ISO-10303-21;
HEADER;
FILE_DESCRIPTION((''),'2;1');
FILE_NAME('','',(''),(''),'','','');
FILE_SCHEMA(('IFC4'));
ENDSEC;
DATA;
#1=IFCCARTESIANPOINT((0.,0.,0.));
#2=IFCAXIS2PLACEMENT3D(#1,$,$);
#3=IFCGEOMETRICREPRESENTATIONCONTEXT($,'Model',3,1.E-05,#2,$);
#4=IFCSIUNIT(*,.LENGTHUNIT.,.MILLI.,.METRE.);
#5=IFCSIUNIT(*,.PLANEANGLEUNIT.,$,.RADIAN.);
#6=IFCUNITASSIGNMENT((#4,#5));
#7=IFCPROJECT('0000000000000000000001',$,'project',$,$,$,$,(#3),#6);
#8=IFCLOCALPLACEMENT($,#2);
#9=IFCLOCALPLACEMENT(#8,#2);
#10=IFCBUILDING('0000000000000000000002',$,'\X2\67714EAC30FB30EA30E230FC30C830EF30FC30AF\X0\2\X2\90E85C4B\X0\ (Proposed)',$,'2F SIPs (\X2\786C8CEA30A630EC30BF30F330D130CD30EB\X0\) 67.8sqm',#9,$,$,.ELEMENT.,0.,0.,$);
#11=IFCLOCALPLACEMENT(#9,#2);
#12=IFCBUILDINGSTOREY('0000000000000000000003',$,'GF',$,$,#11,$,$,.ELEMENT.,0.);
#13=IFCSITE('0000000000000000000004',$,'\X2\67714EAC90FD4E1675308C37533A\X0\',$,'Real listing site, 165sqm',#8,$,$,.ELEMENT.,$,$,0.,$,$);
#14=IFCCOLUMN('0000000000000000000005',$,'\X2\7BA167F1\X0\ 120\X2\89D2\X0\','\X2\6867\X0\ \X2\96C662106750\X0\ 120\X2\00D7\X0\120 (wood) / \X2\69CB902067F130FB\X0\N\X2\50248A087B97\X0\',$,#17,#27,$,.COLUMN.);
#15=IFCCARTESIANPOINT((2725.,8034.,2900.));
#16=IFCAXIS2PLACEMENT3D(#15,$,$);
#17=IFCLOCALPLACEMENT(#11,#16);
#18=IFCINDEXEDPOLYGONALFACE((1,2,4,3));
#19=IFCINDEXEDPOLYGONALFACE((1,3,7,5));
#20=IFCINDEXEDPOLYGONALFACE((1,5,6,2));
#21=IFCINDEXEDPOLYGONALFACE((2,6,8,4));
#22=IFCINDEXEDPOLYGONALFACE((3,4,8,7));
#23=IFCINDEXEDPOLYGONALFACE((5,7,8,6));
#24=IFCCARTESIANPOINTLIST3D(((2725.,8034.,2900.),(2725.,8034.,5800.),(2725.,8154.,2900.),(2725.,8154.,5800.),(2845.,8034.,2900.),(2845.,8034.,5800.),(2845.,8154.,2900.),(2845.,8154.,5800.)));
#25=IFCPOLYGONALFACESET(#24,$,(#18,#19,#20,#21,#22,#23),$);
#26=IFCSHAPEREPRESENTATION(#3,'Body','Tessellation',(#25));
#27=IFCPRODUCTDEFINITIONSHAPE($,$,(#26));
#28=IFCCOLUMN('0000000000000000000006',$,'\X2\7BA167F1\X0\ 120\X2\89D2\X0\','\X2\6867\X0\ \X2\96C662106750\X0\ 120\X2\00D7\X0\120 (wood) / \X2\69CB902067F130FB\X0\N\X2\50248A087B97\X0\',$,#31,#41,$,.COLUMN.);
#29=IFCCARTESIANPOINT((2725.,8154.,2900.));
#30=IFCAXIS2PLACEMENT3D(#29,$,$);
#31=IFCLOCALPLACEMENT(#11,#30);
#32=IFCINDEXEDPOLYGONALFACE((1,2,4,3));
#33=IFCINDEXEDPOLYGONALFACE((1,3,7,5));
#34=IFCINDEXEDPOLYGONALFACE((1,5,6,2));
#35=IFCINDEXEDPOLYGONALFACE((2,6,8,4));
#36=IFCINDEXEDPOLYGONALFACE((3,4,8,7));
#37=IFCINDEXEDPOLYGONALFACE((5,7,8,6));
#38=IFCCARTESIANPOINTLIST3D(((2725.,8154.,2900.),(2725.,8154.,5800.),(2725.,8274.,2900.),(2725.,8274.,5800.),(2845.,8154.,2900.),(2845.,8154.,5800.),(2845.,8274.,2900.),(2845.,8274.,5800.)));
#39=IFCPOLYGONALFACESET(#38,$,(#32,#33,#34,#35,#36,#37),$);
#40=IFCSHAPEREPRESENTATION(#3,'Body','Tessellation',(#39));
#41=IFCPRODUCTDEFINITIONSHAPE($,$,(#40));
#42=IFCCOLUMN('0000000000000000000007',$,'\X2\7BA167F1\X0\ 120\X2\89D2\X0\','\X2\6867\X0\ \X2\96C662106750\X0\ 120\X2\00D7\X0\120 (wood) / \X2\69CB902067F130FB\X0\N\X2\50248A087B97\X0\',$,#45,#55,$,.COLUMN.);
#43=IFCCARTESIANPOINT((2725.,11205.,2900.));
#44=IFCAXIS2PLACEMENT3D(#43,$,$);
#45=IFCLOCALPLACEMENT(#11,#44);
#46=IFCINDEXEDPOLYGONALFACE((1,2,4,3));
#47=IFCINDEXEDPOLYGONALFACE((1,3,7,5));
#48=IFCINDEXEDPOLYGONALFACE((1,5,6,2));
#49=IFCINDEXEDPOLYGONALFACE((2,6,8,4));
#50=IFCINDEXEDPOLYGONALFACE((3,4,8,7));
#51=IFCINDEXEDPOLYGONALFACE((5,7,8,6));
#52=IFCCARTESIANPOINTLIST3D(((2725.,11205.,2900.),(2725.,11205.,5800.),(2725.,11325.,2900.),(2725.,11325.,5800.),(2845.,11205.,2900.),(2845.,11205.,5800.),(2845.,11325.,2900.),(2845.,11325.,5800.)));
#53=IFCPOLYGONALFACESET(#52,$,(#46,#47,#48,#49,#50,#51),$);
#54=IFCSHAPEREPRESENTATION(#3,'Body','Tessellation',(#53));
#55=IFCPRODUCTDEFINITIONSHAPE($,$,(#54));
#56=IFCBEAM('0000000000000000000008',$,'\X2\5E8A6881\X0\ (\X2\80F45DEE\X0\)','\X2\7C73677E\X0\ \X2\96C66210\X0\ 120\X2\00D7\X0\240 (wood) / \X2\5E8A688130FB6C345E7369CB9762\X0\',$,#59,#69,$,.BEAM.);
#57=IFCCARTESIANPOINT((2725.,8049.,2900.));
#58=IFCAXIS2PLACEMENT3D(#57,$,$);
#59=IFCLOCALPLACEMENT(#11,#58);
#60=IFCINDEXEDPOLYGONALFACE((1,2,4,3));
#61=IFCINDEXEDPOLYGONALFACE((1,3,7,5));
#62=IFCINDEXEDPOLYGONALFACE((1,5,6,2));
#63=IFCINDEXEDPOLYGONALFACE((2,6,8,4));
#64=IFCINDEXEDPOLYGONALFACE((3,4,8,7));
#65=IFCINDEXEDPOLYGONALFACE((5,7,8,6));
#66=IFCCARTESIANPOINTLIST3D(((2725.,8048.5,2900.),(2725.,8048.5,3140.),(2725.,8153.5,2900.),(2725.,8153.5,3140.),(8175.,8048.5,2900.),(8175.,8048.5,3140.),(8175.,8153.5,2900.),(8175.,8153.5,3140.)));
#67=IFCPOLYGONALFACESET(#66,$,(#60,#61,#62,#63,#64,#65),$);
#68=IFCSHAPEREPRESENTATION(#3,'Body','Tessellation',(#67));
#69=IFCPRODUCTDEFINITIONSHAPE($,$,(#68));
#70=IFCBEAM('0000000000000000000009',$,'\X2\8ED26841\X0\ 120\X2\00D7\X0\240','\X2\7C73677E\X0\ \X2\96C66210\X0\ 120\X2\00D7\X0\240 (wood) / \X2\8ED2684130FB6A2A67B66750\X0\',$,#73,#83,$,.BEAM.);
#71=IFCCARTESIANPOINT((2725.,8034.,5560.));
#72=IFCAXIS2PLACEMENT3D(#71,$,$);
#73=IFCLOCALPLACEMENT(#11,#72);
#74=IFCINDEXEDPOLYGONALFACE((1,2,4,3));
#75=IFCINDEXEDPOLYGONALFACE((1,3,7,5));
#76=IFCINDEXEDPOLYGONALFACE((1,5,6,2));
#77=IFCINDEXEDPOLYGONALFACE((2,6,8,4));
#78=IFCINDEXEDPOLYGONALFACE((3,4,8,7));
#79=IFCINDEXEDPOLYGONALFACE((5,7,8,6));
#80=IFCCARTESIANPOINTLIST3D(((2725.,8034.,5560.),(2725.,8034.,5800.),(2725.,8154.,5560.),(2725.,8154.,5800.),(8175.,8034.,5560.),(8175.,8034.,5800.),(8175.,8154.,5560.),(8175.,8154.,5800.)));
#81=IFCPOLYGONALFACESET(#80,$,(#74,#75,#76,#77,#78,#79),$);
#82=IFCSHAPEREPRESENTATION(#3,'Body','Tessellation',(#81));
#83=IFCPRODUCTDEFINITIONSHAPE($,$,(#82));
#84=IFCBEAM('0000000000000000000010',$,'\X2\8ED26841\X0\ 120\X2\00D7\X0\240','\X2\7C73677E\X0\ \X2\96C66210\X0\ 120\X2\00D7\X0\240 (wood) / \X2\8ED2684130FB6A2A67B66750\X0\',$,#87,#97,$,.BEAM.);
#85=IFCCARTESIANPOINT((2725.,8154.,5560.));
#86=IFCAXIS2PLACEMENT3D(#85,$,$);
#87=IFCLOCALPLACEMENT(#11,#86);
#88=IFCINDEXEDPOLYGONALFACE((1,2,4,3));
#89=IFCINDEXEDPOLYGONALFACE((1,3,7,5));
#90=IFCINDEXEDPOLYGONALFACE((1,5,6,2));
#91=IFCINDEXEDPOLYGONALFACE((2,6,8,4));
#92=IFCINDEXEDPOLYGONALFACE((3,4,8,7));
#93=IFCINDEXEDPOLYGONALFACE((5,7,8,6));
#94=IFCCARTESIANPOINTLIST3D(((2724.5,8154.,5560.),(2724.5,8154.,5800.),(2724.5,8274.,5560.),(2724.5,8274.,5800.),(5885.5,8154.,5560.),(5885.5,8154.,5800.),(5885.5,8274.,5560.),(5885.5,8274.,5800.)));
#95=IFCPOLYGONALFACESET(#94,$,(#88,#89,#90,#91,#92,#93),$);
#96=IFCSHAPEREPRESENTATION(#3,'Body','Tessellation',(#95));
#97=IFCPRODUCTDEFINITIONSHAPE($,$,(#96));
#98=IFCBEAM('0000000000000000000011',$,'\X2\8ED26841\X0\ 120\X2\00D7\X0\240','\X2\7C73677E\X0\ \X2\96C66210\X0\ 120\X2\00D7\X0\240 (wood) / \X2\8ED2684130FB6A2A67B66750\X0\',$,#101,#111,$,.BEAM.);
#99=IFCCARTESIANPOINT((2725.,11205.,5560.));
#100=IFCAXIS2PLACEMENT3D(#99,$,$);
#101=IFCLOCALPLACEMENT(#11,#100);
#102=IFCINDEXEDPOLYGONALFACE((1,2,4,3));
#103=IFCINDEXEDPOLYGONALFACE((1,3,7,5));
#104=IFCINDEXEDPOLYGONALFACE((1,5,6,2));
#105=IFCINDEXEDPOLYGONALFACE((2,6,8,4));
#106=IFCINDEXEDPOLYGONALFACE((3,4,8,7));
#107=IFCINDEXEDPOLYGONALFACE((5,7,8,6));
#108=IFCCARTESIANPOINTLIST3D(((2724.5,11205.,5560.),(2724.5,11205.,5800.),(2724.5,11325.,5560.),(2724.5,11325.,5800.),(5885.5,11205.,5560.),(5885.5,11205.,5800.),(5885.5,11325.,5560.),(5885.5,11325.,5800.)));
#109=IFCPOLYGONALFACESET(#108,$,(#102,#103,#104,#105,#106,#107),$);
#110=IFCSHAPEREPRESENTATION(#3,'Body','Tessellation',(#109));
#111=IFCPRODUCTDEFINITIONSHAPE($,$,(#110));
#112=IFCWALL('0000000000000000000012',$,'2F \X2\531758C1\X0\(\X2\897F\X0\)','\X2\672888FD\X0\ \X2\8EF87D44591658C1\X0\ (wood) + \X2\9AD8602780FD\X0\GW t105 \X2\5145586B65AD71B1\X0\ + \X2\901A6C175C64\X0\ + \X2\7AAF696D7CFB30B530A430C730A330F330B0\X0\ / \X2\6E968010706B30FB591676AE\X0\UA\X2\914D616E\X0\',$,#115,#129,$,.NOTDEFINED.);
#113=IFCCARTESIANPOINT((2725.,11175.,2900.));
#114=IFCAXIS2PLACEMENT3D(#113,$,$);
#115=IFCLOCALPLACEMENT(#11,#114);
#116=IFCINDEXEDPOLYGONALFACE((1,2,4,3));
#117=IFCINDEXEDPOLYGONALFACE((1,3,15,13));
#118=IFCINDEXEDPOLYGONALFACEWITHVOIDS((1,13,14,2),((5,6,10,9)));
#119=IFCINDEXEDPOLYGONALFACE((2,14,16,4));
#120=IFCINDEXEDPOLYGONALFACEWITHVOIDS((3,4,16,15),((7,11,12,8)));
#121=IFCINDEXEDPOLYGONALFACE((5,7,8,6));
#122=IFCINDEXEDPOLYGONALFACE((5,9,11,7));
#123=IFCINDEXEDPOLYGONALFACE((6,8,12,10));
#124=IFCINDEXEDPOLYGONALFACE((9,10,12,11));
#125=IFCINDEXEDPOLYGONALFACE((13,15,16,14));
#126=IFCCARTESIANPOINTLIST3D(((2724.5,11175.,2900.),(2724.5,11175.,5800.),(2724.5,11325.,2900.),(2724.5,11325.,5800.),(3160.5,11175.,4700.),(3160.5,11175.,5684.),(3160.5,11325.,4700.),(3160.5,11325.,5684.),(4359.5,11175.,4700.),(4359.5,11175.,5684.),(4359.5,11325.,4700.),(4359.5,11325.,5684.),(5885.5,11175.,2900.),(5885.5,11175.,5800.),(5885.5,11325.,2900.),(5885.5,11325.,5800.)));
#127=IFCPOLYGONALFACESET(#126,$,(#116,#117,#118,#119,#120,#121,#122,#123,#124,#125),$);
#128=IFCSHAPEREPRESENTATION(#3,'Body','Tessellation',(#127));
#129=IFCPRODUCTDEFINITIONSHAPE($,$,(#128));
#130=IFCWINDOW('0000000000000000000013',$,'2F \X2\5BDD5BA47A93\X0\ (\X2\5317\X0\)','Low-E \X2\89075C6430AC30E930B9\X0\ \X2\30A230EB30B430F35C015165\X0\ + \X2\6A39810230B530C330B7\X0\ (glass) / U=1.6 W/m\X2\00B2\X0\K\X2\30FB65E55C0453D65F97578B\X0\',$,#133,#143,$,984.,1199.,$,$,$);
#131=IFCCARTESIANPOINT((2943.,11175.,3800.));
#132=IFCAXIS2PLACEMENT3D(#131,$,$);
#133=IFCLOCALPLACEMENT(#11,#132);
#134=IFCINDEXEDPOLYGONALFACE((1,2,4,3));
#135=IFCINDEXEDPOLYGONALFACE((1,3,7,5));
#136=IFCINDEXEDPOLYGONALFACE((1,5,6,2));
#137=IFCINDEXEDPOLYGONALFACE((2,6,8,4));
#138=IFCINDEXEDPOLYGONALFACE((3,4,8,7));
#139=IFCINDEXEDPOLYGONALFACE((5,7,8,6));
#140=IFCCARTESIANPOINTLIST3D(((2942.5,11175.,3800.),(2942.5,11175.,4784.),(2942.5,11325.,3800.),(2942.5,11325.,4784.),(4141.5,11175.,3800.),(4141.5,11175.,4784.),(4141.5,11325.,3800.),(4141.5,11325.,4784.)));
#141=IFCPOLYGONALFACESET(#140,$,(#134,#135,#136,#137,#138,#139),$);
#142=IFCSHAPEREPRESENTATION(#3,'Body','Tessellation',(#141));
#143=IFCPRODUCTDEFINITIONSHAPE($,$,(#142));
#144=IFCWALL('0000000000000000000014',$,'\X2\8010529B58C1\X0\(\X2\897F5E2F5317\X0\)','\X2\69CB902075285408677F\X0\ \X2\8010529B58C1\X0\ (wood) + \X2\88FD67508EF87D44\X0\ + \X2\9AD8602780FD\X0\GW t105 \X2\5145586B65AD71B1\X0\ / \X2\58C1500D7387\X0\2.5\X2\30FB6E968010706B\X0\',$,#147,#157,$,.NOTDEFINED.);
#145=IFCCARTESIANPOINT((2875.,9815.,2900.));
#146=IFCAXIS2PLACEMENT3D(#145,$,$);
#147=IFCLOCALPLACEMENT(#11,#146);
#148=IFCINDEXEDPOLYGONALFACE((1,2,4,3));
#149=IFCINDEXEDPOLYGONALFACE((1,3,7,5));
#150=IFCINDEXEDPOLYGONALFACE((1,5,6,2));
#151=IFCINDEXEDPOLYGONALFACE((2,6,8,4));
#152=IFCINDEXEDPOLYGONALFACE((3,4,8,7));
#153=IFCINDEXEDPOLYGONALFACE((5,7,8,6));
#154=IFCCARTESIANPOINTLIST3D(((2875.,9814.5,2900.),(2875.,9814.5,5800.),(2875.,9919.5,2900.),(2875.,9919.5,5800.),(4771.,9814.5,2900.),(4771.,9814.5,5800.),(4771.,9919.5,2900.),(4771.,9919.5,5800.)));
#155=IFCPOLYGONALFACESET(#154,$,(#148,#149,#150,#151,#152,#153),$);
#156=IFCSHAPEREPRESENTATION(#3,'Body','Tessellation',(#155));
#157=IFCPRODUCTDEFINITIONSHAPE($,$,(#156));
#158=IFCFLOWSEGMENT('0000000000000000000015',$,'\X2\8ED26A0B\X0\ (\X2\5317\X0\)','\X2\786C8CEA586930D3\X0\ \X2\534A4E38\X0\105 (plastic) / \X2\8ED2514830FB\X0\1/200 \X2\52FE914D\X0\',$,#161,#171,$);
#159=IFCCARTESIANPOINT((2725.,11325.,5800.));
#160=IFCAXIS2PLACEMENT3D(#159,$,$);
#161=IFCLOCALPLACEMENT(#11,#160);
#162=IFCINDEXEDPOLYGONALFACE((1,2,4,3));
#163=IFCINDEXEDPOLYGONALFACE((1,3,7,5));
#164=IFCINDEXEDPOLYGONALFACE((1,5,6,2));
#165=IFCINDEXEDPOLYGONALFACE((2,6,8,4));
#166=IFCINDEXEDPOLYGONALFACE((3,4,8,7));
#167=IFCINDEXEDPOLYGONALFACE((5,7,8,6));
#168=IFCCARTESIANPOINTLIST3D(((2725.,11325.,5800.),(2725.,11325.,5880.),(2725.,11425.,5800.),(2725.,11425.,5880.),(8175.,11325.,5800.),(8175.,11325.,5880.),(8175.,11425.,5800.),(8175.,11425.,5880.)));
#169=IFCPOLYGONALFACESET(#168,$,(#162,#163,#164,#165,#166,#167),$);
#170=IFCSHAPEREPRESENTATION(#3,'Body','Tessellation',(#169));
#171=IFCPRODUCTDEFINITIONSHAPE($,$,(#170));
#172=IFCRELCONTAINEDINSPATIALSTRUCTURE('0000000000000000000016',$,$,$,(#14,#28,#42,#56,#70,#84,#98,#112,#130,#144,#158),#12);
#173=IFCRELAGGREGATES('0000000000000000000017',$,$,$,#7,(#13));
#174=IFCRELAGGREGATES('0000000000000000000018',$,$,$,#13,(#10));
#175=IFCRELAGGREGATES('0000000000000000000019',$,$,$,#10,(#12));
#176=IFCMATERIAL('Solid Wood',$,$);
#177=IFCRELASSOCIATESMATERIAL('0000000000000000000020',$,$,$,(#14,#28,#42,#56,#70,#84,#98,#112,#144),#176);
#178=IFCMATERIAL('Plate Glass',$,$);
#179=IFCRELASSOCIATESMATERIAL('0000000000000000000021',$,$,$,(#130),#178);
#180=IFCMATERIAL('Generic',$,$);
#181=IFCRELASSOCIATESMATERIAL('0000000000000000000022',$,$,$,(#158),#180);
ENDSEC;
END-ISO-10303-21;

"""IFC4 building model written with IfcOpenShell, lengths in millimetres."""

from ifc_helpers import new_model, si_unit, frame, frame_2d, origin, place, context, project, spatial, rectangle, extrude, material, element, fill, save


model = new_model("IFC4")

# Units and contexts
model_context = context("Model", 3, precision=1e-05, world=origin())
ifc_project = project(units=[si_unit("LENGTHUNIT", "METRE", prefix="MILLI"), si_unit("PLANEANGLEUNIT", "RADIAN")], contexts=[model_context])

# Site, building, storey
site_placement = place(None, origin())
site = spatial("IfcSite", under=ifc_project, at=site_placement, Name="東京都世田谷区", ObjectType="Real listing site, 165sqm", CompositionType="ELEMENT", RefElevation=0.0)
building_placement = place(site_placement, origin())
building = spatial("IfcBuilding", under=site, at=building_placement, Name="東京・リモートワーク2部屋 (Proposed)", ObjectType="2F SIPs (硬質ウレタンパネル) 67.8sqm", CompositionType="ELEMENT", ElevationOfRefHeight=0.0, ElevationOfTerrain=0.0)
storey_placement = place(building_placement, origin())
storey = spatial("IfcBuildingStorey", under=building, at=storey_placement, Name="GF", CompositionType="ELEMENT", Elevation=0.0)

# Columns
ifc_material_1 = material(Name="Solid Wood")
column_1_placement = place(storey_placement, frame((2725.0, 8034.0, 2900.0)))
element("IfcColumn", 1, at=column_1_placement, inside=storey, material=ifc_material_1, Name="管柱 120角", Description="桧 集成材 120×120 (wood) / 構造柱・N値計算", PredefinedType="COLUMN", context=model_context, shape_type="SweptSolid", body=[
    extrude(rectangle(XDim=120.0, YDim=120.0, at=frame_2d((60.0, 60.0))), frame((2725.0, 8034.0, 2900.0)), (0.0, 0.0, 1.0), 2900.0),
])
column_2_placement = place(storey_placement, frame((2725.0, 8154.0, 2900.0)))
element("IfcColumn", 2, at=column_2_placement, inside=storey, material=ifc_material_1, Name="管柱 120角", Description="桧 集成材 120×120 (wood) / 構造柱・N値計算", PredefinedType="COLUMN", context=model_context, shape_type="SweptSolid", body=[
    extrude(rectangle(XDim=120.0, YDim=120.0, at=frame_2d((60.0, 60.0))), frame((2725.0, 8154.0, 2900.0)), (0.0, 0.0, 1.0), 2900.0),
])
column_3_placement = place(storey_placement, frame((2725.0, 11205.0, 2900.0)))
element("IfcColumn", 3, at=column_3_placement, inside=storey, material=ifc_material_1, Name="管柱 120角", Description="桧 集成材 120×120 (wood) / 構造柱・N値計算", PredefinedType="COLUMN", context=model_context, shape_type="SweptSolid", body=[
    extrude(rectangle(XDim=120.0, YDim=120.0, at=frame_2d((60.0, 60.0))), frame((2725.0, 11205.0, 2900.0)), (0.0, 0.0, 1.0), 2900.0),
])

# Beams
beam_1_placement = place(storey_placement, frame((2725.0, 8049.0, 2900.0)))
element("IfcBeam", 4, at=beam_1_placement, inside=storey, material=ifc_material_1, Name="床梁 (胴差)", Description="米松 集成 120×240 (wood) / 床梁・水平構面", PredefinedType="BEAM", context=model_context, shape_type="SweptSolid", body=[
    extrude(rectangle(XDim=5450.0, YDim=105.0, at=frame_2d((2725.0, 52.0))), frame((2725.0, 8049.0, 2900.0)), (0.0, 0.0, 1.0), 240.0),
])
beam_2_placement = place(storey_placement, frame((2725.0, 8034.0, 5560.0)))
element("IfcBeam", 5, at=beam_2_placement, inside=storey, material=ifc_material_1, Name="軒桁 120×240", Description="米松 集成 120×240 (wood) / 軒桁・横架材", PredefinedType="BEAM", context=model_context, shape_type="SweptSolid", body=[
    extrude(rectangle(XDim=5450.0, YDim=120.0, at=frame_2d((2725.0, 60.0))), frame((2725.0, 8034.0, 5560.0)), (0.0, 0.0, 1.0), 240.0),
])
beam_3_placement = place(storey_placement, frame((2725.0, 8154.0, 5560.0)))
element("IfcBeam", 6, at=beam_3_placement, inside=storey, material=ifc_material_1, Name="軒桁 120×240", Description="米松 集成 120×240 (wood) / 軒桁・横架材", PredefinedType="BEAM", context=model_context, shape_type="SweptSolid", body=[
    extrude(rectangle(XDim=3161.0, YDim=120.0, at=frame_2d((1580.0, 60.0))), frame((2725.0, 8154.0, 5560.0)), (0.0, 0.0, 1.0), 240.0),
])
beam_4_placement = place(storey_placement, frame((2725.0, 11205.0, 5560.0)))
element("IfcBeam", 7, at=beam_4_placement, inside=storey, material=ifc_material_1, Name="軒桁 120×240", Description="米松 集成 120×240 (wood) / 軒桁・横架材", PredefinedType="BEAM", context=model_context, shape_type="SweptSolid", body=[
    extrude(rectangle(XDim=3161.0, YDim=120.0, at=frame_2d((1580.0, 60.0))), frame((2725.0, 11205.0, 5560.0)), (0.0, 0.0, 1.0), 240.0),
])

# Wall, opening, window
wall_1_placement = place(storey_placement, frame((2725.0, 11175.0, 2900.0)))
wall_1 = element("IfcWall", 8, at=wall_1_placement, inside=storey, material=ifc_material_1, Name="2F 北壁(西)", Description="木製 軸組外壁 (wood) + 高性能GW t105 充填断熱 + 通気層 + 窯業系サイディング / 準耐火・外皮UA配慮", PredefinedType="NOTDEFINED", context=model_context, shape_type="SweptSolid", body=[
    extrude(rectangle(XDim=3161.0, YDim=150.0, at=frame_2d((1580.0, 75.0))), frame((2725.0, 11175.0, 2900.0)), (0.0, 0.0, 1.0), 2900.0),
])
opening_placement = place(storey_placement, frame((2943.0, 11175.0, 3800.0)))
opening = element("IfcOpeningElement", 9, at=opening_placement, cuts=wall_1, PredefinedType="NOTDEFINED", context=model_context, shape_type="SweptSolid", body=[
    extrude(rectangle(XDim=1199.0, YDim=150.0, at=frame_2d((599.0, 75.0))), frame((2943.0, 11175.0, 3800.0)), (0.0, 0.0, 1.0), 984.0),
])
ifc_material_2 = material(Name="Plate Glass")
window_placement = place(storey_placement, frame((2943.0, 11175.0, 3800.0)))
window = element("IfcWindow", 10, at=window_placement, inside=storey, material=ifc_material_2, Name="2F 寝室窓 (北)", Description="Low-E 複層ガラス アルゴン封入 + 樹脂サッシ (glass) / U=1.6 W/m²K・日射取得型", OverallHeight=984.0, OverallWidth=1199.0, context=model_context, shape_type="SweptSolid", body=[
    extrude(rectangle(XDim=1199.0, YDim=150.0, at=frame_2d((599.0, 75.0))), frame((2943.0, 11175.0, 3800.0)), (0.0, 0.0, 1.0), 984.0),
])
fill(opening, window)

# Wall
wall_2_placement = place(storey_placement, frame((2875.0, 9815.0, 2900.0)))
element("IfcWall", 11, at=wall_2_placement, inside=storey, material=ifc_material_1, Name="耐力壁(西帯北)", Description="構造用合板 耐力壁 (wood) + 製材軸組 + 高性能GW t105 充填断熱 / 壁倍率2.5・準耐火", PredefinedType="NOTDEFINED", context=model_context, shape_type="SweptSolid", body=[
    extrude(rectangle(XDim=1896.0, YDim=105.0, at=frame_2d((948.0, 52.0))), frame((2875.0, 9815.0, 2900.0)), (0.0, 0.0, 1.0), 2900.0),
])

# Shared definitions
ifc_material_3 = material(Name="Generic")

# Flow segment
flow_segment_placement = place(storey_placement, frame((2725.0, 11325.0, 5800.0)))
element("IfcFlowSegment", 12, at=flow_segment_placement, inside=storey, material=ifc_material_3, Name="軒樋 (北)", Description="硬質塩ビ 半丸105 (plastic) / 軒先・1/200 勾配", context=model_context, shape_type="SweptSolid", body=[
    extrude(rectangle(XDim=5450.0, YDim=100.0, at=frame_2d((2725.0, 50.0))), frame((2725.0, 11325.0, 5800.0)), (0.0, 0.0, 1.0), 80.0),
])

save(model, "model.ifc")
